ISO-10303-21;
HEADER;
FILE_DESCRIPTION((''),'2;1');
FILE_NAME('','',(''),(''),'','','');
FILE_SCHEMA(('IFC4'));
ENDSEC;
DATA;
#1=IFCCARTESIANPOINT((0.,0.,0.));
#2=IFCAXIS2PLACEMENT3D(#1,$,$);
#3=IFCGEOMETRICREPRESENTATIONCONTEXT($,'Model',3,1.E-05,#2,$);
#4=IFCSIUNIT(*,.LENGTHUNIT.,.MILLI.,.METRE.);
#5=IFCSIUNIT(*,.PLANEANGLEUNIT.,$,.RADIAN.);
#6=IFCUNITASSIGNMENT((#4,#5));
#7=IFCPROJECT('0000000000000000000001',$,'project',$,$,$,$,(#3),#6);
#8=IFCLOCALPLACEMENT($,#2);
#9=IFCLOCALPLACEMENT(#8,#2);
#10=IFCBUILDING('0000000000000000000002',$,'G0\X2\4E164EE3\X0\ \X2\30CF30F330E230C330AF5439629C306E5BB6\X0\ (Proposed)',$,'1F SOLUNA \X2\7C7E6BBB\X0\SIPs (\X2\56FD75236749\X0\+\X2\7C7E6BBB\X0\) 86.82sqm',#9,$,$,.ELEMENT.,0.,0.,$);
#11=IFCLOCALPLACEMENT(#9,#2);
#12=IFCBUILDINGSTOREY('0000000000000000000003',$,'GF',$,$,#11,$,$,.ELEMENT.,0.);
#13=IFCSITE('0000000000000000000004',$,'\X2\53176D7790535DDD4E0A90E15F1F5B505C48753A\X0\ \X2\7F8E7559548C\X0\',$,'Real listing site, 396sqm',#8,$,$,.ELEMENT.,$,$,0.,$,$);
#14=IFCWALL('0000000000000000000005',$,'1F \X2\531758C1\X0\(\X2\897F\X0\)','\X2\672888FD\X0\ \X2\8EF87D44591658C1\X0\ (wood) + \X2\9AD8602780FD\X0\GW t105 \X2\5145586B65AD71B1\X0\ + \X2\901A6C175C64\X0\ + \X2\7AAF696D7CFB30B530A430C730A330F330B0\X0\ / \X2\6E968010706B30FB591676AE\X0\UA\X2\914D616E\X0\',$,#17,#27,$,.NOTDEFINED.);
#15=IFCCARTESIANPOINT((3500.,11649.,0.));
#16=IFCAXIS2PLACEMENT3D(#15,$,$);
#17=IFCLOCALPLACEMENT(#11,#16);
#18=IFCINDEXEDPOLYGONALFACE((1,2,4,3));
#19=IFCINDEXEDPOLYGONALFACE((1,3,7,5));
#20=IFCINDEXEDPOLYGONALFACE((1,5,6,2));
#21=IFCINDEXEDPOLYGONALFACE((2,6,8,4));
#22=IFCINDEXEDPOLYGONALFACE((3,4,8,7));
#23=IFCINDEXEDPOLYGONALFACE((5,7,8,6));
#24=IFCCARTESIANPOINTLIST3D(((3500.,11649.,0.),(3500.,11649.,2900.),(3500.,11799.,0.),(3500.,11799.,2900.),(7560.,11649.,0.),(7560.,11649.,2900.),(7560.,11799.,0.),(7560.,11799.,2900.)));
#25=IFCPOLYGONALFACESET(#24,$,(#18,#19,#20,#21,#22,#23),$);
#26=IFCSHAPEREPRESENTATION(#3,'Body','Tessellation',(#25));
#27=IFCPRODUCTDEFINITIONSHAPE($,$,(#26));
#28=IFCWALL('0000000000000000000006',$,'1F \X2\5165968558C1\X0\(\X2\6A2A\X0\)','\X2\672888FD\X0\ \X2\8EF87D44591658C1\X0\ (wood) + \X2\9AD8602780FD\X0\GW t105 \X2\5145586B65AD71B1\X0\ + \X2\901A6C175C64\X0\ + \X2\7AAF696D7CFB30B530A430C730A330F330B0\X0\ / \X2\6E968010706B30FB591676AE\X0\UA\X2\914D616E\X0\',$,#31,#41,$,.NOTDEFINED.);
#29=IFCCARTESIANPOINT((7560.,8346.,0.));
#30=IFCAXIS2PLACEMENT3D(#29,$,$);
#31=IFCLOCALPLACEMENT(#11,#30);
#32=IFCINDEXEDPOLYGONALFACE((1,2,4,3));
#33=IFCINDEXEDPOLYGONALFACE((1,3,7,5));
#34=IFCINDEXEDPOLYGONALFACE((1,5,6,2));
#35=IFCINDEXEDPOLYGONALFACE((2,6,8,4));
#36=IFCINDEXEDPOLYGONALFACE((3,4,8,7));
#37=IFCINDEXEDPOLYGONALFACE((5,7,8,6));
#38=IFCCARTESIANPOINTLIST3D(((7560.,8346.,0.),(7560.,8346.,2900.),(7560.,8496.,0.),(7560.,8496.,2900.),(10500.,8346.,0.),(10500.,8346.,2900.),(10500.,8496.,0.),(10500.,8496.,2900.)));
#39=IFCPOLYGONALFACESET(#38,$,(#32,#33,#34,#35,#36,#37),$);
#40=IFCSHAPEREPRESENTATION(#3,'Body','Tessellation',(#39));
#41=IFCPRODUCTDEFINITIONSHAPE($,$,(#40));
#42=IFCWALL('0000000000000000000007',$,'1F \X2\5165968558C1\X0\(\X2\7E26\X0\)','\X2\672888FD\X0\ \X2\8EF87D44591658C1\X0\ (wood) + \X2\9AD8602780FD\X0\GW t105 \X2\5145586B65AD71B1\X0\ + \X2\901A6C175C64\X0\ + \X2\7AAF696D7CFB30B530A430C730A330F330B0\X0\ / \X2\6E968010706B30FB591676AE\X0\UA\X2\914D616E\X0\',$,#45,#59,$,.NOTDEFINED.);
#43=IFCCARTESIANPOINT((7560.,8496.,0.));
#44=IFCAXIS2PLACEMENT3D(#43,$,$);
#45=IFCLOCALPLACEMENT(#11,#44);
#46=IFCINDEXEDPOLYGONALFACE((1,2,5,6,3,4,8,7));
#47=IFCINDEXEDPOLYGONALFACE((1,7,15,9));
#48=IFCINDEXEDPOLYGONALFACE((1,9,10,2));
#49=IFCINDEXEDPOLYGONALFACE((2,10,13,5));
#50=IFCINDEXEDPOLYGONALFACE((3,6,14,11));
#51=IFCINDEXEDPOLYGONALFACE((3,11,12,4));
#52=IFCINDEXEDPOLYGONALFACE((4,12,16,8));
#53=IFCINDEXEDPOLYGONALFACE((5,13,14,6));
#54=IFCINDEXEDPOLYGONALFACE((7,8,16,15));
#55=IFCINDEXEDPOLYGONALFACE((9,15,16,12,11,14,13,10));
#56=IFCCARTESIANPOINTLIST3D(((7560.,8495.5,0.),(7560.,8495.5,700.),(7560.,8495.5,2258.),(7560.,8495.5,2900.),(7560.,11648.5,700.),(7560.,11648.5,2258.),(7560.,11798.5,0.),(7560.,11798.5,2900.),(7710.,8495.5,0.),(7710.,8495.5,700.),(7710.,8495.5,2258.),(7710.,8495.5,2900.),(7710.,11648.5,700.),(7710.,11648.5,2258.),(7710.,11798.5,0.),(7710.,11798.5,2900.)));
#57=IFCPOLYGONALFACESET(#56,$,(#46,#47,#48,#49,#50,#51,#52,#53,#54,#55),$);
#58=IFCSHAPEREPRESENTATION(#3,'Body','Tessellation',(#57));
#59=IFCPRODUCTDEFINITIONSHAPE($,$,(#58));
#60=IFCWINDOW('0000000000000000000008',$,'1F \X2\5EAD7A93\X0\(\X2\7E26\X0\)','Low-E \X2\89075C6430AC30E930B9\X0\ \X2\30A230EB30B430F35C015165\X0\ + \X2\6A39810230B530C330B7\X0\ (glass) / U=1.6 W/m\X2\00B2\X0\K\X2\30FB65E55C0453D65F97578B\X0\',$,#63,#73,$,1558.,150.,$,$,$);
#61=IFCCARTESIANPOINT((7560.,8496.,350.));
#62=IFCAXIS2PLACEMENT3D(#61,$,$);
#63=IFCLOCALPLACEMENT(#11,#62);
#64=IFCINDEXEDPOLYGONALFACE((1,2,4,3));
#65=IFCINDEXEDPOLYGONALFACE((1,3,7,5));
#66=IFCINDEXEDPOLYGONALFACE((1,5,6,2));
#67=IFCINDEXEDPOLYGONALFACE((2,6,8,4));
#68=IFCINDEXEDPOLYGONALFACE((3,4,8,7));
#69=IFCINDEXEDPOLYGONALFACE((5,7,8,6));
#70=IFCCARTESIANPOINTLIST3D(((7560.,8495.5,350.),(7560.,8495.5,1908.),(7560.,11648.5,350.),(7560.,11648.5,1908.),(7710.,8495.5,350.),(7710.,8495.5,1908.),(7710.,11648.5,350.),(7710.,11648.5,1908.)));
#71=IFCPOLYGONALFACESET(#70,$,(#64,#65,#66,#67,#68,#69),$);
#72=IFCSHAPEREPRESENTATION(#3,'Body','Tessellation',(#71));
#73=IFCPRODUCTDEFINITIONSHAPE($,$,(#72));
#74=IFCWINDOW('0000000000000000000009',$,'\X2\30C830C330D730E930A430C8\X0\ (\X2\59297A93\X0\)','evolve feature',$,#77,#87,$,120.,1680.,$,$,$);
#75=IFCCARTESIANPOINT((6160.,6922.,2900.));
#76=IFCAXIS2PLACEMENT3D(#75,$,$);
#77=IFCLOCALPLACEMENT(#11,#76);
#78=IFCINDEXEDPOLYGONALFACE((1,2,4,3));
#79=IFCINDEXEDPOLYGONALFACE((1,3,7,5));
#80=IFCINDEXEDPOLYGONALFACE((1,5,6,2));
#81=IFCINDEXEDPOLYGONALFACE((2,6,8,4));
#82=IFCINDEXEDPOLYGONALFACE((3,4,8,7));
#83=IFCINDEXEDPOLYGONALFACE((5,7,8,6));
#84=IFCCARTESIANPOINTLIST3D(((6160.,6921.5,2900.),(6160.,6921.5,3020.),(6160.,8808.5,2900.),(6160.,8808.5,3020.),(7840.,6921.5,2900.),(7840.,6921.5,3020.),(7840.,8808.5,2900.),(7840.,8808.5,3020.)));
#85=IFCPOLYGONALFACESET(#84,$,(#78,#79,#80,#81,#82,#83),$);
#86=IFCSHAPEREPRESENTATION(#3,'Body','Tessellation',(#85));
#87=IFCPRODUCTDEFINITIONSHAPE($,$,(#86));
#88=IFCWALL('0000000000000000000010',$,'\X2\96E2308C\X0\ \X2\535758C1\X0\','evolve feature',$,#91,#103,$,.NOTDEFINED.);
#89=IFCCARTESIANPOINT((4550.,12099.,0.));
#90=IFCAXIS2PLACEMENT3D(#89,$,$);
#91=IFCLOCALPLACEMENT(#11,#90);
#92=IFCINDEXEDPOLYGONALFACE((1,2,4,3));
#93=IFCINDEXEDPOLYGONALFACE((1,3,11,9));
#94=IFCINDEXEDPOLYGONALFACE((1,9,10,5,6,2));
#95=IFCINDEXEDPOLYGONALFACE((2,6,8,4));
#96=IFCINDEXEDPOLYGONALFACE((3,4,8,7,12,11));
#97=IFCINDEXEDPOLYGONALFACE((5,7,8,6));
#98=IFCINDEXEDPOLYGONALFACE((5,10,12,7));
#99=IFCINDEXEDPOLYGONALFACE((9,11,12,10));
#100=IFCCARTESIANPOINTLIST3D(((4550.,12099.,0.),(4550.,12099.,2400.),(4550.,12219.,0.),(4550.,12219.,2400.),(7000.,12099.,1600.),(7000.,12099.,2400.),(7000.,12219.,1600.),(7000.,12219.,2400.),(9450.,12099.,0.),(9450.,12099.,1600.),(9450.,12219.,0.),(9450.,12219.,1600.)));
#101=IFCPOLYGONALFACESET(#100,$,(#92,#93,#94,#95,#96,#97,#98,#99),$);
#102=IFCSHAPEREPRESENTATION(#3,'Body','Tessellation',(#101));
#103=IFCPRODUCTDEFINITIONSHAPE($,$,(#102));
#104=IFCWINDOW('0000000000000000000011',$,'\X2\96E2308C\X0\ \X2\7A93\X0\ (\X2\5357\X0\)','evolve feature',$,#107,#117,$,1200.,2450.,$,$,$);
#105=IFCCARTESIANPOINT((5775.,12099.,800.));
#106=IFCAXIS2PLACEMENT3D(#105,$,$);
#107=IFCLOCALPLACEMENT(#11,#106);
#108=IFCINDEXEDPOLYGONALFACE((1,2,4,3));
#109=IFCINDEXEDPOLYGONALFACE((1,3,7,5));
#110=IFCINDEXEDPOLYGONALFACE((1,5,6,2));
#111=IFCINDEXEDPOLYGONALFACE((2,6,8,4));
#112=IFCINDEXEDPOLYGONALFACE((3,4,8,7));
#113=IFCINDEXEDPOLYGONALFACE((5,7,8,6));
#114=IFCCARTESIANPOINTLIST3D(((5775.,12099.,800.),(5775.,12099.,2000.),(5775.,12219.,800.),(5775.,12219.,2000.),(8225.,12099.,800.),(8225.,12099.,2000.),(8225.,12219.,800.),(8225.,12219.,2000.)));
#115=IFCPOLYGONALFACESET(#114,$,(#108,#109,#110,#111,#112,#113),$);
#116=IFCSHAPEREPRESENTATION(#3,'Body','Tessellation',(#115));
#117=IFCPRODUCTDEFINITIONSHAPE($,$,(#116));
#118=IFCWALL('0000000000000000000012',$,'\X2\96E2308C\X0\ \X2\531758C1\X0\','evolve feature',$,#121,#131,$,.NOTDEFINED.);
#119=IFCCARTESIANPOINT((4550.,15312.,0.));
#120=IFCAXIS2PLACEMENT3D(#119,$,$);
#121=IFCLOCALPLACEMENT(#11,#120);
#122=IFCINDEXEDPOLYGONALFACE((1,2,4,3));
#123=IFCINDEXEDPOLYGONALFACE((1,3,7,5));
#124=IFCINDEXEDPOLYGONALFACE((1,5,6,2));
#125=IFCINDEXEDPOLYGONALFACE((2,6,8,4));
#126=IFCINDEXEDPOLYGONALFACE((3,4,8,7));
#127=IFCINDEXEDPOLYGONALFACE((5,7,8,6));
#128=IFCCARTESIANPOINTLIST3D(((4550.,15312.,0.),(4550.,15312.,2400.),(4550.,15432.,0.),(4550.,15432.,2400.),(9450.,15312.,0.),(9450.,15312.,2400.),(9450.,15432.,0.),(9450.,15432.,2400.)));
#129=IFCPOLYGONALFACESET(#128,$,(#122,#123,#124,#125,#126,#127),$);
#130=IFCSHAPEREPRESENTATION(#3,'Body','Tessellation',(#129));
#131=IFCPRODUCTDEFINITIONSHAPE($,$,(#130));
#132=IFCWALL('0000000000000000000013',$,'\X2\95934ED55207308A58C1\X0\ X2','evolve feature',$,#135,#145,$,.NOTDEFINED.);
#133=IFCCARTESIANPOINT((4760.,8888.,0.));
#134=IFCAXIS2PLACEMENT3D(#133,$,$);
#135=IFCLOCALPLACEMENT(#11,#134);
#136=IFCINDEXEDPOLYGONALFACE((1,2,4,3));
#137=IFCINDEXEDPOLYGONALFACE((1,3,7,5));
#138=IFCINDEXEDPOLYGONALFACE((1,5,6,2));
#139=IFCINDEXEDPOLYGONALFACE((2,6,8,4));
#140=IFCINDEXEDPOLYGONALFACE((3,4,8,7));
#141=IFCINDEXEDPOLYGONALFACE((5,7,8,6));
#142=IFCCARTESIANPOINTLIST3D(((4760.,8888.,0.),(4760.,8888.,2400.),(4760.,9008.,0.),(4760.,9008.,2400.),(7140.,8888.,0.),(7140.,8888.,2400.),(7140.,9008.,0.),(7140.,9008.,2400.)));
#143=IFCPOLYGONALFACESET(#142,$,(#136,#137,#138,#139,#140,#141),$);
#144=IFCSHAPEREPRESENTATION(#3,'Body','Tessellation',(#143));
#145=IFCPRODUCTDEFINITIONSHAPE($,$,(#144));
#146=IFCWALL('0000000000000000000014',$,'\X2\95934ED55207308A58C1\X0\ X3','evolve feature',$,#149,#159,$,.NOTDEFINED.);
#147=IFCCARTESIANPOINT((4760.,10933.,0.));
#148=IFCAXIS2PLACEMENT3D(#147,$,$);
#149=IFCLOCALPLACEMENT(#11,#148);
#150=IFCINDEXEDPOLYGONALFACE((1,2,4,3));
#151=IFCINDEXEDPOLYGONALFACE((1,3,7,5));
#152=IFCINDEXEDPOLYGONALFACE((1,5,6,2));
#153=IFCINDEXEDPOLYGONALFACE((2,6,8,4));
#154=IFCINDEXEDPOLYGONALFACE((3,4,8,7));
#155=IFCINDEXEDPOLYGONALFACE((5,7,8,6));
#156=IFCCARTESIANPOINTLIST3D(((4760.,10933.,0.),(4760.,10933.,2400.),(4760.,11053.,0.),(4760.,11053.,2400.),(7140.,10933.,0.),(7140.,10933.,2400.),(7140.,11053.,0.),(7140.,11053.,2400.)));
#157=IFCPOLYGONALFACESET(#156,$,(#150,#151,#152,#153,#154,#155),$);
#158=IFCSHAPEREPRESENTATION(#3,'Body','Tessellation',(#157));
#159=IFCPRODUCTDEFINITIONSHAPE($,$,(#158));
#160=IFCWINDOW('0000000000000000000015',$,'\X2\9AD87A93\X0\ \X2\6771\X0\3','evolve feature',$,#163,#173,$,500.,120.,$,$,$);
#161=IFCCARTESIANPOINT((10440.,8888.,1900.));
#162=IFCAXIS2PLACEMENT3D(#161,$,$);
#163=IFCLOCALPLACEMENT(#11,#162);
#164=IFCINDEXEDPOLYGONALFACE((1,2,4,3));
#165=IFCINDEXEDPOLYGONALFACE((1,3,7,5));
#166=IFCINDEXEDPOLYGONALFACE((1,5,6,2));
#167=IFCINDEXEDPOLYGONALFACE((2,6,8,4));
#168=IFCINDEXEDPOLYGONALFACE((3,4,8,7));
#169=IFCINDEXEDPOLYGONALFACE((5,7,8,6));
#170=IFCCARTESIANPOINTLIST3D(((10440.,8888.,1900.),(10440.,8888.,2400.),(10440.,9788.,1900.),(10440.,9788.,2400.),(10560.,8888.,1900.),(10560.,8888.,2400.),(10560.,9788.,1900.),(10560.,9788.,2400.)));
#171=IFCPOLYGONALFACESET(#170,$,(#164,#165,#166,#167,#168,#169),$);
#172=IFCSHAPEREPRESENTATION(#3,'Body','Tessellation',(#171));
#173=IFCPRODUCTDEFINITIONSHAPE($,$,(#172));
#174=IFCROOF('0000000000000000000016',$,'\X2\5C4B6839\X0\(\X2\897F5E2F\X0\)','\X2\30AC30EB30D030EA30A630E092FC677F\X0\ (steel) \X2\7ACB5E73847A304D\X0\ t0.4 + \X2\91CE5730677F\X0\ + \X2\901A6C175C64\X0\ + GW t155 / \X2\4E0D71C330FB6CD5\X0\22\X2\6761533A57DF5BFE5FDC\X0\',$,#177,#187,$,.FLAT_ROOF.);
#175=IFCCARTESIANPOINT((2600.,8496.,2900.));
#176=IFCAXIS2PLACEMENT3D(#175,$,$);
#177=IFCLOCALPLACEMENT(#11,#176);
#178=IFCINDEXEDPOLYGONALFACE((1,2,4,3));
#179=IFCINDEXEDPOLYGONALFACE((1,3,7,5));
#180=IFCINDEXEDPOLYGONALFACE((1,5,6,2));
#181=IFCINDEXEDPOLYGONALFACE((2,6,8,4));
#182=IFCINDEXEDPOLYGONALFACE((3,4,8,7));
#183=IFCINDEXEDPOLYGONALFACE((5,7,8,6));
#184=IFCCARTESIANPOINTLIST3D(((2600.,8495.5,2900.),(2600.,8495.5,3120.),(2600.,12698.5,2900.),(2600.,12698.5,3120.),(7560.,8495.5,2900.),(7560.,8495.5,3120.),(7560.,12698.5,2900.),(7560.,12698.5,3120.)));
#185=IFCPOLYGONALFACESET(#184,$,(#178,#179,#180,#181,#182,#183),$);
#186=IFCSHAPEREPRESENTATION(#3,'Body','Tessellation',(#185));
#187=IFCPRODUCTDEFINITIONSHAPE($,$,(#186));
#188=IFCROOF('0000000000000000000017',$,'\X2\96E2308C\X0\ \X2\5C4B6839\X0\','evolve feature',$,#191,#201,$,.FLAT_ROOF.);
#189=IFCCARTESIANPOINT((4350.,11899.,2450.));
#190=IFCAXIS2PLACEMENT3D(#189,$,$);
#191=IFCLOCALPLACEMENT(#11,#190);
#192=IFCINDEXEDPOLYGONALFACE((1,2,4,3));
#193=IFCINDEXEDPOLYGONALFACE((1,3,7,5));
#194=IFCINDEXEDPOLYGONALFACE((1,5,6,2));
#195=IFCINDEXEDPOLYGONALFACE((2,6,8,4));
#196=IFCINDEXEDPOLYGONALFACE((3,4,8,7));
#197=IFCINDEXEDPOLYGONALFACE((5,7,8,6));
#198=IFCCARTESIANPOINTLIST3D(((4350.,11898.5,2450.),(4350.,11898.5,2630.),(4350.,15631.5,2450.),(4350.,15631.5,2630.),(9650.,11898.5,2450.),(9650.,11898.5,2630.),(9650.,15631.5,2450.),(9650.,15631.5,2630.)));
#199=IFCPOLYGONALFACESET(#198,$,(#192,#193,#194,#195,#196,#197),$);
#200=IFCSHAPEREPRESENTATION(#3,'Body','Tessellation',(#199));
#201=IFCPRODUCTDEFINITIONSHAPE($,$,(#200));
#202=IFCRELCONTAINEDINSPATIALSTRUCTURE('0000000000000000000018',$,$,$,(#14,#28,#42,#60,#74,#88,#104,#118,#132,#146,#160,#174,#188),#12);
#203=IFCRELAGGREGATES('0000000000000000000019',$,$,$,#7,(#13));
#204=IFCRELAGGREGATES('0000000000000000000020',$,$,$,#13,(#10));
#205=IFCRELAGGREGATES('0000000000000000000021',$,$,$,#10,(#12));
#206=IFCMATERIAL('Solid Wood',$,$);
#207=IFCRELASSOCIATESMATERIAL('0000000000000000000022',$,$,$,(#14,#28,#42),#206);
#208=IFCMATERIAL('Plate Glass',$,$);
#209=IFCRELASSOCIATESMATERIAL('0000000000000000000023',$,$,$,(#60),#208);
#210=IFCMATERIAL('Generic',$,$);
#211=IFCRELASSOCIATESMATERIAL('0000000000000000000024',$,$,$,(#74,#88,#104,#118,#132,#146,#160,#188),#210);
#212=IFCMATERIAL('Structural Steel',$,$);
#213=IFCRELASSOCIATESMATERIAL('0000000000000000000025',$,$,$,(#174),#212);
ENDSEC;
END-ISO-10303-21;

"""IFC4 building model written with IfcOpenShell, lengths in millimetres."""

from ifc_helpers import new_model, si_unit, frame, frame_2d, origin, place, context, project, spatial, rectangle, extrude, material, element, fill, save


model = new_model("IFC4")

# Units and contexts
model_context = context("Model", 3, precision=1e-05, world=origin())
ifc_project = project(units=[si_unit("LENGTHUNIT", "METRE", prefix="MILLI"), si_unit("PLANEANGLEUNIT", "RADIAN")], contexts=[model_context])

# Site, building, storey
site_placement = place(None, origin())
site = spatial("IfcSite", under=ifc_project, at=site_placement, Name="北海道川上郡弟子屈町 美留和", ObjectType="Real listing site, 396sqm", CompositionType="ELEMENT", RefElevation=0.0)
building_placement = place(site_placement, origin())
building = spatial("IfcBuilding", under=site, at=building_placement, Name="G0世代 ハンモック吹抜の家 (Proposed)", ObjectType="1F SOLUNA 籾殻SIPs (国産杉+籾殻) 86.82sqm", CompositionType="ELEMENT", ElevationOfRefHeight=0.0, ElevationOfTerrain=0.0)
storey_placement = place(building_placement, origin())
storey = spatial("IfcBuildingStorey", under=building, at=storey_placement, Name="GF", CompositionType="ELEMENT", Elevation=0.0)

# Shared definitions
ifc_material_1 = material(Name="Solid Wood")
ifc_material_2 = material(Name="Generic")

# Walls
wall_1_placement = place(storey_placement, frame((3500.0, 11649.0, 0.0)))
element("IfcWall", 1, at=wall_1_placement, inside=storey, material=ifc_material_1, Name="1F 北壁(西)", Description="木製 軸組外壁 (wood) + 高性能GW t105 充填断熱 + 通気層 + 窯業系サイディング / 準耐火・外皮UA配慮", PredefinedType="NOTDEFINED", context=model_context, shape_type="SweptSolid", body=[
    extrude(rectangle(XDim=4060.0, YDim=150.0, at=frame_2d((2030.0, 75.0))), frame((3500.0, 11649.0, 0.0)), (0.0, 0.0, 1.0), 2900.0),
])
wall_2_placement = place(storey_placement, frame((7560.0, 8346.0, 0.0)))
element("IfcWall", 2, at=wall_2_placement, inside=storey, material=ifc_material_1, Name="1F 入隅壁(横)", Description="木製 軸組外壁 (wood) + 高性能GW t105 充填断熱 + 通気層 + 窯業系サイディング / 準耐火・外皮UA配慮", PredefinedType="NOTDEFINED", context=model_context, shape_type="SweptSolid", body=[
    extrude(rectangle(XDim=2940.0, YDim=150.0, at=frame_2d((1470.0, 75.0))), frame((7560.0, 8346.0, 0.0)), (0.0, 0.0, 1.0), 2900.0),
])

# Wall, opening, window
wall_3_placement = place(storey_placement, frame((7560.0, 8496.0, 0.0)))
wall_3 = element("IfcWall", 3, at=wall_3_placement, inside=storey, material=ifc_material_1, Name="1F 入隅壁(縦)", Description="木製 軸組外壁 (wood) + 高性能GW t105 充填断熱 + 通気層 + 窯業系サイディング / 準耐火・外皮UA配慮", PredefinedType="NOTDEFINED", context=model_context, shape_type="SweptSolid", body=[
    extrude(rectangle(XDim=150.0, YDim=3303.0, at=frame_2d((75.0, 1651.0))), frame((7560.0, 8496.0, 0.0)), (0.0, 0.0, 1.0), 2900.0),
])
opening_1_placement = place(storey_placement, frame((7560.0, 8496.0, 350.0)))
opening_1 = element("IfcOpeningElement", 4, at=opening_1_placement, cuts=wall_3, PredefinedType="NOTDEFINED", context=model_context, shape_type="SweptSolid", body=[
    extrude(rectangle(XDim=150.0, YDim=3153.0, at=frame_2d((75.0, 1576.0))), frame((7560.0, 8496.0, 350.0)), (0.0, 0.0, 1.0), 1558.0),
])
ifc_material_3 = material(Name="Plate Glass")
window_1_placement = place(storey_placement, frame((7560.0, 8496.0, 350.0)))
window_1 = element("IfcWindow", 5, at=window_1_placement, inside=storey, material=ifc_material_3, Name="1F 庭窓(縦)", Description="Low-E 複層ガラス アルゴン封入 + 樹脂サッシ (glass) / U=1.6 W/m²K・日射取得型", OverallHeight=1558.0, OverallWidth=150.0, context=model_context, shape_type="SweptSolid", body=[
    extrude(rectangle(XDim=150.0, YDim=3153.0, at=frame_2d((75.0, 1576.0))), frame((7560.0, 8496.0, 350.0)), (0.0, 0.0, 1.0), 1558.0),
])
fill(opening_1, window_1)

# Window
window_2_placement = place(storey_placement, frame((6160.0, 6922.0, 2900.0)))
element("IfcWindow", 6, at=window_2_placement, inside=storey, material=ifc_material_2, Name="トップライト (天窓)", Description="evolve feature", OverallHeight=120.0, OverallWidth=1680.0, context=model_context, shape_type="SweptSolid", body=[
    extrude(rectangle(XDim=1680.0, YDim=1887.0, at=frame_2d((840.0, 943.0))), frame((6160.0, 6922.0, 2900.0)), (0.0, 0.0, 1.0), 120.0),
])

# Wall, opening, window
wall_4_placement = place(storey_placement, frame((4550.0, 12099.0, 0.0)))
wall_4 = element("IfcWall", 7, at=wall_4_placement, inside=storey, material=ifc_material_2, Name="離れ 南壁", Description="evolve feature", PredefinedType="NOTDEFINED", context=model_context, shape_type="SweptSolid", body=[
    extrude(rectangle(XDim=4900.0, YDim=120.0, at=frame_2d((2450.0, 60.0))), frame((4550.0, 12099.0, 0.0)), (0.0, 0.0, 1.0), 2400.0),
])
opening_2_placement = place(storey_placement, frame((5775.0, 12099.0, 800.0)))
opening_2 = element("IfcOpeningElement", 8, at=opening_2_placement, cuts=wall_4, PredefinedType="NOTDEFINED", context=model_context, shape_type="SweptSolid", body=[
    extrude(rectangle(XDim=2450.0, YDim=120.0, at=frame_2d((1225.0, 60.0))), frame((5775.0, 12099.0, 800.0)), (0.0, 0.0, 1.0), 1200.0),
])
window_3_placement = place(storey_placement, frame((5775.0, 12099.0, 800.0)))
window_3 = element("IfcWindow", 9, at=window_3_placement, inside=storey, material=ifc_material_2, Name="離れ 窓 (南)", Description="evolve feature", OverallHeight=1200.0, OverallWidth=2450.0, context=model_context, shape_type="SweptSolid", body=[
    extrude(rectangle(XDim=2450.0, YDim=120.0, at=frame_2d((1225.0, 60.0))), frame((5775.0, 12099.0, 800.0)), (0.0, 0.0, 1.0), 1200.0),
])
fill(opening_2, window_3)

# Walls
wall_5_placement = place(storey_placement, frame((4550.0, 15312.0, 0.0)))
element("IfcWall", 10, at=wall_5_placement, inside=storey, material=ifc_material_2, Name="離れ 北壁", Description="evolve feature", PredefinedType="NOTDEFINED", context=model_context, shape_type="SweptSolid", body=[
    extrude(rectangle(XDim=4900.0, YDim=120.0, at=frame_2d((2450.0, 60.0))), frame((4550.0, 15312.0, 0.0)), (0.0, 0.0, 1.0), 2400.0),
])
wall_6_placement = place(storey_placement, frame((4760.0, 8888.0, 0.0)))
element("IfcWall", 11, at=wall_6_placement, inside=storey, material=ifc_material_2, Name="間仕切り壁 X2", Description="evolve feature", PredefinedType="NOTDEFINED", context=model_context, shape_type="SweptSolid", body=[
    extrude(rectangle(XDim=2380.0, YDim=120.0, at=frame_2d((1190.0, 60.0))), frame((4760.0, 8888.0, 0.0)), (0.0, 0.0, 1.0), 2400.0),
])
wall_7_placement = place(storey_placement, frame((4760.0, 10933.0, 0.0)))
element("IfcWall", 12, at=wall_7_placement, inside=storey, material=ifc_material_2, Name="間仕切り壁 X3", Description="evolve feature", PredefinedType="NOTDEFINED", context=model_context, shape_type="SweptSolid", body=[
    extrude(rectangle(XDim=2380.0, YDim=120.0, at=frame_2d((1190.0, 60.0))), frame((4760.0, 10933.0, 0.0)), (0.0, 0.0, 1.0), 2400.0),
])

# Window
window_4_placement = place(storey_placement, frame((10440.0, 8888.0, 1900.0)))
element("IfcWindow", 13, at=window_4_placement, inside=storey, material=ifc_material_2, Name="高窓 東3", Description="evolve feature", OverallHeight=500.0, OverallWidth=120.0, context=model_context, shape_type="SweptSolid", body=[
    extrude(rectangle(XDim=120.0, YDim=900.0, at=frame_2d((60.0, 450.0))), frame((10440.0, 8888.0, 1900.0)), (0.0, 0.0, 1.0), 500.0),
])

# Roofs
ifc_material_4 = material(Name="Structural Steel")
roof_1_placement = place(storey_placement, frame((2600.0, 8496.0, 2900.0)))
element("IfcRoof", 14, at=roof_1_placement, inside=storey, material=ifc_material_4, Name="屋根(西帯)", Description="ガルバリウム鋼板 (steel) 立平葺き t0.4 + 野地板 + 通気層 + GW t155 / 不燃・法22条区域対応", PredefinedType="FLAT_ROOF", context=model_context, shape_type="SweptSolid", body=[
    extrude(rectangle(XDim=4960.0, YDim=4203.0, at=frame_2d((2480.0, 2101.0))), frame((2600.0, 8496.0, 2900.0)), (0.0, 0.0, 1.0), 220.0),
])
roof_2_placement = place(storey_placement, frame((4350.0, 11899.0, 2450.0)))
element("IfcRoof", 15, at=roof_2_placement, inside=storey, material=ifc_material_2, Name="離れ 屋根", Description="evolve feature", PredefinedType="FLAT_ROOF", context=model_context, shape_type="SweptSolid", body=[
    extrude(rectangle(XDim=5300.0, YDim=3733.0, at=frame_2d((2650.0, 1866.0))), frame((4350.0, 11899.0, 2450.0)), (0.0, 0.0, 1.0), 180.0),
])

save(model, "model.ifc")
